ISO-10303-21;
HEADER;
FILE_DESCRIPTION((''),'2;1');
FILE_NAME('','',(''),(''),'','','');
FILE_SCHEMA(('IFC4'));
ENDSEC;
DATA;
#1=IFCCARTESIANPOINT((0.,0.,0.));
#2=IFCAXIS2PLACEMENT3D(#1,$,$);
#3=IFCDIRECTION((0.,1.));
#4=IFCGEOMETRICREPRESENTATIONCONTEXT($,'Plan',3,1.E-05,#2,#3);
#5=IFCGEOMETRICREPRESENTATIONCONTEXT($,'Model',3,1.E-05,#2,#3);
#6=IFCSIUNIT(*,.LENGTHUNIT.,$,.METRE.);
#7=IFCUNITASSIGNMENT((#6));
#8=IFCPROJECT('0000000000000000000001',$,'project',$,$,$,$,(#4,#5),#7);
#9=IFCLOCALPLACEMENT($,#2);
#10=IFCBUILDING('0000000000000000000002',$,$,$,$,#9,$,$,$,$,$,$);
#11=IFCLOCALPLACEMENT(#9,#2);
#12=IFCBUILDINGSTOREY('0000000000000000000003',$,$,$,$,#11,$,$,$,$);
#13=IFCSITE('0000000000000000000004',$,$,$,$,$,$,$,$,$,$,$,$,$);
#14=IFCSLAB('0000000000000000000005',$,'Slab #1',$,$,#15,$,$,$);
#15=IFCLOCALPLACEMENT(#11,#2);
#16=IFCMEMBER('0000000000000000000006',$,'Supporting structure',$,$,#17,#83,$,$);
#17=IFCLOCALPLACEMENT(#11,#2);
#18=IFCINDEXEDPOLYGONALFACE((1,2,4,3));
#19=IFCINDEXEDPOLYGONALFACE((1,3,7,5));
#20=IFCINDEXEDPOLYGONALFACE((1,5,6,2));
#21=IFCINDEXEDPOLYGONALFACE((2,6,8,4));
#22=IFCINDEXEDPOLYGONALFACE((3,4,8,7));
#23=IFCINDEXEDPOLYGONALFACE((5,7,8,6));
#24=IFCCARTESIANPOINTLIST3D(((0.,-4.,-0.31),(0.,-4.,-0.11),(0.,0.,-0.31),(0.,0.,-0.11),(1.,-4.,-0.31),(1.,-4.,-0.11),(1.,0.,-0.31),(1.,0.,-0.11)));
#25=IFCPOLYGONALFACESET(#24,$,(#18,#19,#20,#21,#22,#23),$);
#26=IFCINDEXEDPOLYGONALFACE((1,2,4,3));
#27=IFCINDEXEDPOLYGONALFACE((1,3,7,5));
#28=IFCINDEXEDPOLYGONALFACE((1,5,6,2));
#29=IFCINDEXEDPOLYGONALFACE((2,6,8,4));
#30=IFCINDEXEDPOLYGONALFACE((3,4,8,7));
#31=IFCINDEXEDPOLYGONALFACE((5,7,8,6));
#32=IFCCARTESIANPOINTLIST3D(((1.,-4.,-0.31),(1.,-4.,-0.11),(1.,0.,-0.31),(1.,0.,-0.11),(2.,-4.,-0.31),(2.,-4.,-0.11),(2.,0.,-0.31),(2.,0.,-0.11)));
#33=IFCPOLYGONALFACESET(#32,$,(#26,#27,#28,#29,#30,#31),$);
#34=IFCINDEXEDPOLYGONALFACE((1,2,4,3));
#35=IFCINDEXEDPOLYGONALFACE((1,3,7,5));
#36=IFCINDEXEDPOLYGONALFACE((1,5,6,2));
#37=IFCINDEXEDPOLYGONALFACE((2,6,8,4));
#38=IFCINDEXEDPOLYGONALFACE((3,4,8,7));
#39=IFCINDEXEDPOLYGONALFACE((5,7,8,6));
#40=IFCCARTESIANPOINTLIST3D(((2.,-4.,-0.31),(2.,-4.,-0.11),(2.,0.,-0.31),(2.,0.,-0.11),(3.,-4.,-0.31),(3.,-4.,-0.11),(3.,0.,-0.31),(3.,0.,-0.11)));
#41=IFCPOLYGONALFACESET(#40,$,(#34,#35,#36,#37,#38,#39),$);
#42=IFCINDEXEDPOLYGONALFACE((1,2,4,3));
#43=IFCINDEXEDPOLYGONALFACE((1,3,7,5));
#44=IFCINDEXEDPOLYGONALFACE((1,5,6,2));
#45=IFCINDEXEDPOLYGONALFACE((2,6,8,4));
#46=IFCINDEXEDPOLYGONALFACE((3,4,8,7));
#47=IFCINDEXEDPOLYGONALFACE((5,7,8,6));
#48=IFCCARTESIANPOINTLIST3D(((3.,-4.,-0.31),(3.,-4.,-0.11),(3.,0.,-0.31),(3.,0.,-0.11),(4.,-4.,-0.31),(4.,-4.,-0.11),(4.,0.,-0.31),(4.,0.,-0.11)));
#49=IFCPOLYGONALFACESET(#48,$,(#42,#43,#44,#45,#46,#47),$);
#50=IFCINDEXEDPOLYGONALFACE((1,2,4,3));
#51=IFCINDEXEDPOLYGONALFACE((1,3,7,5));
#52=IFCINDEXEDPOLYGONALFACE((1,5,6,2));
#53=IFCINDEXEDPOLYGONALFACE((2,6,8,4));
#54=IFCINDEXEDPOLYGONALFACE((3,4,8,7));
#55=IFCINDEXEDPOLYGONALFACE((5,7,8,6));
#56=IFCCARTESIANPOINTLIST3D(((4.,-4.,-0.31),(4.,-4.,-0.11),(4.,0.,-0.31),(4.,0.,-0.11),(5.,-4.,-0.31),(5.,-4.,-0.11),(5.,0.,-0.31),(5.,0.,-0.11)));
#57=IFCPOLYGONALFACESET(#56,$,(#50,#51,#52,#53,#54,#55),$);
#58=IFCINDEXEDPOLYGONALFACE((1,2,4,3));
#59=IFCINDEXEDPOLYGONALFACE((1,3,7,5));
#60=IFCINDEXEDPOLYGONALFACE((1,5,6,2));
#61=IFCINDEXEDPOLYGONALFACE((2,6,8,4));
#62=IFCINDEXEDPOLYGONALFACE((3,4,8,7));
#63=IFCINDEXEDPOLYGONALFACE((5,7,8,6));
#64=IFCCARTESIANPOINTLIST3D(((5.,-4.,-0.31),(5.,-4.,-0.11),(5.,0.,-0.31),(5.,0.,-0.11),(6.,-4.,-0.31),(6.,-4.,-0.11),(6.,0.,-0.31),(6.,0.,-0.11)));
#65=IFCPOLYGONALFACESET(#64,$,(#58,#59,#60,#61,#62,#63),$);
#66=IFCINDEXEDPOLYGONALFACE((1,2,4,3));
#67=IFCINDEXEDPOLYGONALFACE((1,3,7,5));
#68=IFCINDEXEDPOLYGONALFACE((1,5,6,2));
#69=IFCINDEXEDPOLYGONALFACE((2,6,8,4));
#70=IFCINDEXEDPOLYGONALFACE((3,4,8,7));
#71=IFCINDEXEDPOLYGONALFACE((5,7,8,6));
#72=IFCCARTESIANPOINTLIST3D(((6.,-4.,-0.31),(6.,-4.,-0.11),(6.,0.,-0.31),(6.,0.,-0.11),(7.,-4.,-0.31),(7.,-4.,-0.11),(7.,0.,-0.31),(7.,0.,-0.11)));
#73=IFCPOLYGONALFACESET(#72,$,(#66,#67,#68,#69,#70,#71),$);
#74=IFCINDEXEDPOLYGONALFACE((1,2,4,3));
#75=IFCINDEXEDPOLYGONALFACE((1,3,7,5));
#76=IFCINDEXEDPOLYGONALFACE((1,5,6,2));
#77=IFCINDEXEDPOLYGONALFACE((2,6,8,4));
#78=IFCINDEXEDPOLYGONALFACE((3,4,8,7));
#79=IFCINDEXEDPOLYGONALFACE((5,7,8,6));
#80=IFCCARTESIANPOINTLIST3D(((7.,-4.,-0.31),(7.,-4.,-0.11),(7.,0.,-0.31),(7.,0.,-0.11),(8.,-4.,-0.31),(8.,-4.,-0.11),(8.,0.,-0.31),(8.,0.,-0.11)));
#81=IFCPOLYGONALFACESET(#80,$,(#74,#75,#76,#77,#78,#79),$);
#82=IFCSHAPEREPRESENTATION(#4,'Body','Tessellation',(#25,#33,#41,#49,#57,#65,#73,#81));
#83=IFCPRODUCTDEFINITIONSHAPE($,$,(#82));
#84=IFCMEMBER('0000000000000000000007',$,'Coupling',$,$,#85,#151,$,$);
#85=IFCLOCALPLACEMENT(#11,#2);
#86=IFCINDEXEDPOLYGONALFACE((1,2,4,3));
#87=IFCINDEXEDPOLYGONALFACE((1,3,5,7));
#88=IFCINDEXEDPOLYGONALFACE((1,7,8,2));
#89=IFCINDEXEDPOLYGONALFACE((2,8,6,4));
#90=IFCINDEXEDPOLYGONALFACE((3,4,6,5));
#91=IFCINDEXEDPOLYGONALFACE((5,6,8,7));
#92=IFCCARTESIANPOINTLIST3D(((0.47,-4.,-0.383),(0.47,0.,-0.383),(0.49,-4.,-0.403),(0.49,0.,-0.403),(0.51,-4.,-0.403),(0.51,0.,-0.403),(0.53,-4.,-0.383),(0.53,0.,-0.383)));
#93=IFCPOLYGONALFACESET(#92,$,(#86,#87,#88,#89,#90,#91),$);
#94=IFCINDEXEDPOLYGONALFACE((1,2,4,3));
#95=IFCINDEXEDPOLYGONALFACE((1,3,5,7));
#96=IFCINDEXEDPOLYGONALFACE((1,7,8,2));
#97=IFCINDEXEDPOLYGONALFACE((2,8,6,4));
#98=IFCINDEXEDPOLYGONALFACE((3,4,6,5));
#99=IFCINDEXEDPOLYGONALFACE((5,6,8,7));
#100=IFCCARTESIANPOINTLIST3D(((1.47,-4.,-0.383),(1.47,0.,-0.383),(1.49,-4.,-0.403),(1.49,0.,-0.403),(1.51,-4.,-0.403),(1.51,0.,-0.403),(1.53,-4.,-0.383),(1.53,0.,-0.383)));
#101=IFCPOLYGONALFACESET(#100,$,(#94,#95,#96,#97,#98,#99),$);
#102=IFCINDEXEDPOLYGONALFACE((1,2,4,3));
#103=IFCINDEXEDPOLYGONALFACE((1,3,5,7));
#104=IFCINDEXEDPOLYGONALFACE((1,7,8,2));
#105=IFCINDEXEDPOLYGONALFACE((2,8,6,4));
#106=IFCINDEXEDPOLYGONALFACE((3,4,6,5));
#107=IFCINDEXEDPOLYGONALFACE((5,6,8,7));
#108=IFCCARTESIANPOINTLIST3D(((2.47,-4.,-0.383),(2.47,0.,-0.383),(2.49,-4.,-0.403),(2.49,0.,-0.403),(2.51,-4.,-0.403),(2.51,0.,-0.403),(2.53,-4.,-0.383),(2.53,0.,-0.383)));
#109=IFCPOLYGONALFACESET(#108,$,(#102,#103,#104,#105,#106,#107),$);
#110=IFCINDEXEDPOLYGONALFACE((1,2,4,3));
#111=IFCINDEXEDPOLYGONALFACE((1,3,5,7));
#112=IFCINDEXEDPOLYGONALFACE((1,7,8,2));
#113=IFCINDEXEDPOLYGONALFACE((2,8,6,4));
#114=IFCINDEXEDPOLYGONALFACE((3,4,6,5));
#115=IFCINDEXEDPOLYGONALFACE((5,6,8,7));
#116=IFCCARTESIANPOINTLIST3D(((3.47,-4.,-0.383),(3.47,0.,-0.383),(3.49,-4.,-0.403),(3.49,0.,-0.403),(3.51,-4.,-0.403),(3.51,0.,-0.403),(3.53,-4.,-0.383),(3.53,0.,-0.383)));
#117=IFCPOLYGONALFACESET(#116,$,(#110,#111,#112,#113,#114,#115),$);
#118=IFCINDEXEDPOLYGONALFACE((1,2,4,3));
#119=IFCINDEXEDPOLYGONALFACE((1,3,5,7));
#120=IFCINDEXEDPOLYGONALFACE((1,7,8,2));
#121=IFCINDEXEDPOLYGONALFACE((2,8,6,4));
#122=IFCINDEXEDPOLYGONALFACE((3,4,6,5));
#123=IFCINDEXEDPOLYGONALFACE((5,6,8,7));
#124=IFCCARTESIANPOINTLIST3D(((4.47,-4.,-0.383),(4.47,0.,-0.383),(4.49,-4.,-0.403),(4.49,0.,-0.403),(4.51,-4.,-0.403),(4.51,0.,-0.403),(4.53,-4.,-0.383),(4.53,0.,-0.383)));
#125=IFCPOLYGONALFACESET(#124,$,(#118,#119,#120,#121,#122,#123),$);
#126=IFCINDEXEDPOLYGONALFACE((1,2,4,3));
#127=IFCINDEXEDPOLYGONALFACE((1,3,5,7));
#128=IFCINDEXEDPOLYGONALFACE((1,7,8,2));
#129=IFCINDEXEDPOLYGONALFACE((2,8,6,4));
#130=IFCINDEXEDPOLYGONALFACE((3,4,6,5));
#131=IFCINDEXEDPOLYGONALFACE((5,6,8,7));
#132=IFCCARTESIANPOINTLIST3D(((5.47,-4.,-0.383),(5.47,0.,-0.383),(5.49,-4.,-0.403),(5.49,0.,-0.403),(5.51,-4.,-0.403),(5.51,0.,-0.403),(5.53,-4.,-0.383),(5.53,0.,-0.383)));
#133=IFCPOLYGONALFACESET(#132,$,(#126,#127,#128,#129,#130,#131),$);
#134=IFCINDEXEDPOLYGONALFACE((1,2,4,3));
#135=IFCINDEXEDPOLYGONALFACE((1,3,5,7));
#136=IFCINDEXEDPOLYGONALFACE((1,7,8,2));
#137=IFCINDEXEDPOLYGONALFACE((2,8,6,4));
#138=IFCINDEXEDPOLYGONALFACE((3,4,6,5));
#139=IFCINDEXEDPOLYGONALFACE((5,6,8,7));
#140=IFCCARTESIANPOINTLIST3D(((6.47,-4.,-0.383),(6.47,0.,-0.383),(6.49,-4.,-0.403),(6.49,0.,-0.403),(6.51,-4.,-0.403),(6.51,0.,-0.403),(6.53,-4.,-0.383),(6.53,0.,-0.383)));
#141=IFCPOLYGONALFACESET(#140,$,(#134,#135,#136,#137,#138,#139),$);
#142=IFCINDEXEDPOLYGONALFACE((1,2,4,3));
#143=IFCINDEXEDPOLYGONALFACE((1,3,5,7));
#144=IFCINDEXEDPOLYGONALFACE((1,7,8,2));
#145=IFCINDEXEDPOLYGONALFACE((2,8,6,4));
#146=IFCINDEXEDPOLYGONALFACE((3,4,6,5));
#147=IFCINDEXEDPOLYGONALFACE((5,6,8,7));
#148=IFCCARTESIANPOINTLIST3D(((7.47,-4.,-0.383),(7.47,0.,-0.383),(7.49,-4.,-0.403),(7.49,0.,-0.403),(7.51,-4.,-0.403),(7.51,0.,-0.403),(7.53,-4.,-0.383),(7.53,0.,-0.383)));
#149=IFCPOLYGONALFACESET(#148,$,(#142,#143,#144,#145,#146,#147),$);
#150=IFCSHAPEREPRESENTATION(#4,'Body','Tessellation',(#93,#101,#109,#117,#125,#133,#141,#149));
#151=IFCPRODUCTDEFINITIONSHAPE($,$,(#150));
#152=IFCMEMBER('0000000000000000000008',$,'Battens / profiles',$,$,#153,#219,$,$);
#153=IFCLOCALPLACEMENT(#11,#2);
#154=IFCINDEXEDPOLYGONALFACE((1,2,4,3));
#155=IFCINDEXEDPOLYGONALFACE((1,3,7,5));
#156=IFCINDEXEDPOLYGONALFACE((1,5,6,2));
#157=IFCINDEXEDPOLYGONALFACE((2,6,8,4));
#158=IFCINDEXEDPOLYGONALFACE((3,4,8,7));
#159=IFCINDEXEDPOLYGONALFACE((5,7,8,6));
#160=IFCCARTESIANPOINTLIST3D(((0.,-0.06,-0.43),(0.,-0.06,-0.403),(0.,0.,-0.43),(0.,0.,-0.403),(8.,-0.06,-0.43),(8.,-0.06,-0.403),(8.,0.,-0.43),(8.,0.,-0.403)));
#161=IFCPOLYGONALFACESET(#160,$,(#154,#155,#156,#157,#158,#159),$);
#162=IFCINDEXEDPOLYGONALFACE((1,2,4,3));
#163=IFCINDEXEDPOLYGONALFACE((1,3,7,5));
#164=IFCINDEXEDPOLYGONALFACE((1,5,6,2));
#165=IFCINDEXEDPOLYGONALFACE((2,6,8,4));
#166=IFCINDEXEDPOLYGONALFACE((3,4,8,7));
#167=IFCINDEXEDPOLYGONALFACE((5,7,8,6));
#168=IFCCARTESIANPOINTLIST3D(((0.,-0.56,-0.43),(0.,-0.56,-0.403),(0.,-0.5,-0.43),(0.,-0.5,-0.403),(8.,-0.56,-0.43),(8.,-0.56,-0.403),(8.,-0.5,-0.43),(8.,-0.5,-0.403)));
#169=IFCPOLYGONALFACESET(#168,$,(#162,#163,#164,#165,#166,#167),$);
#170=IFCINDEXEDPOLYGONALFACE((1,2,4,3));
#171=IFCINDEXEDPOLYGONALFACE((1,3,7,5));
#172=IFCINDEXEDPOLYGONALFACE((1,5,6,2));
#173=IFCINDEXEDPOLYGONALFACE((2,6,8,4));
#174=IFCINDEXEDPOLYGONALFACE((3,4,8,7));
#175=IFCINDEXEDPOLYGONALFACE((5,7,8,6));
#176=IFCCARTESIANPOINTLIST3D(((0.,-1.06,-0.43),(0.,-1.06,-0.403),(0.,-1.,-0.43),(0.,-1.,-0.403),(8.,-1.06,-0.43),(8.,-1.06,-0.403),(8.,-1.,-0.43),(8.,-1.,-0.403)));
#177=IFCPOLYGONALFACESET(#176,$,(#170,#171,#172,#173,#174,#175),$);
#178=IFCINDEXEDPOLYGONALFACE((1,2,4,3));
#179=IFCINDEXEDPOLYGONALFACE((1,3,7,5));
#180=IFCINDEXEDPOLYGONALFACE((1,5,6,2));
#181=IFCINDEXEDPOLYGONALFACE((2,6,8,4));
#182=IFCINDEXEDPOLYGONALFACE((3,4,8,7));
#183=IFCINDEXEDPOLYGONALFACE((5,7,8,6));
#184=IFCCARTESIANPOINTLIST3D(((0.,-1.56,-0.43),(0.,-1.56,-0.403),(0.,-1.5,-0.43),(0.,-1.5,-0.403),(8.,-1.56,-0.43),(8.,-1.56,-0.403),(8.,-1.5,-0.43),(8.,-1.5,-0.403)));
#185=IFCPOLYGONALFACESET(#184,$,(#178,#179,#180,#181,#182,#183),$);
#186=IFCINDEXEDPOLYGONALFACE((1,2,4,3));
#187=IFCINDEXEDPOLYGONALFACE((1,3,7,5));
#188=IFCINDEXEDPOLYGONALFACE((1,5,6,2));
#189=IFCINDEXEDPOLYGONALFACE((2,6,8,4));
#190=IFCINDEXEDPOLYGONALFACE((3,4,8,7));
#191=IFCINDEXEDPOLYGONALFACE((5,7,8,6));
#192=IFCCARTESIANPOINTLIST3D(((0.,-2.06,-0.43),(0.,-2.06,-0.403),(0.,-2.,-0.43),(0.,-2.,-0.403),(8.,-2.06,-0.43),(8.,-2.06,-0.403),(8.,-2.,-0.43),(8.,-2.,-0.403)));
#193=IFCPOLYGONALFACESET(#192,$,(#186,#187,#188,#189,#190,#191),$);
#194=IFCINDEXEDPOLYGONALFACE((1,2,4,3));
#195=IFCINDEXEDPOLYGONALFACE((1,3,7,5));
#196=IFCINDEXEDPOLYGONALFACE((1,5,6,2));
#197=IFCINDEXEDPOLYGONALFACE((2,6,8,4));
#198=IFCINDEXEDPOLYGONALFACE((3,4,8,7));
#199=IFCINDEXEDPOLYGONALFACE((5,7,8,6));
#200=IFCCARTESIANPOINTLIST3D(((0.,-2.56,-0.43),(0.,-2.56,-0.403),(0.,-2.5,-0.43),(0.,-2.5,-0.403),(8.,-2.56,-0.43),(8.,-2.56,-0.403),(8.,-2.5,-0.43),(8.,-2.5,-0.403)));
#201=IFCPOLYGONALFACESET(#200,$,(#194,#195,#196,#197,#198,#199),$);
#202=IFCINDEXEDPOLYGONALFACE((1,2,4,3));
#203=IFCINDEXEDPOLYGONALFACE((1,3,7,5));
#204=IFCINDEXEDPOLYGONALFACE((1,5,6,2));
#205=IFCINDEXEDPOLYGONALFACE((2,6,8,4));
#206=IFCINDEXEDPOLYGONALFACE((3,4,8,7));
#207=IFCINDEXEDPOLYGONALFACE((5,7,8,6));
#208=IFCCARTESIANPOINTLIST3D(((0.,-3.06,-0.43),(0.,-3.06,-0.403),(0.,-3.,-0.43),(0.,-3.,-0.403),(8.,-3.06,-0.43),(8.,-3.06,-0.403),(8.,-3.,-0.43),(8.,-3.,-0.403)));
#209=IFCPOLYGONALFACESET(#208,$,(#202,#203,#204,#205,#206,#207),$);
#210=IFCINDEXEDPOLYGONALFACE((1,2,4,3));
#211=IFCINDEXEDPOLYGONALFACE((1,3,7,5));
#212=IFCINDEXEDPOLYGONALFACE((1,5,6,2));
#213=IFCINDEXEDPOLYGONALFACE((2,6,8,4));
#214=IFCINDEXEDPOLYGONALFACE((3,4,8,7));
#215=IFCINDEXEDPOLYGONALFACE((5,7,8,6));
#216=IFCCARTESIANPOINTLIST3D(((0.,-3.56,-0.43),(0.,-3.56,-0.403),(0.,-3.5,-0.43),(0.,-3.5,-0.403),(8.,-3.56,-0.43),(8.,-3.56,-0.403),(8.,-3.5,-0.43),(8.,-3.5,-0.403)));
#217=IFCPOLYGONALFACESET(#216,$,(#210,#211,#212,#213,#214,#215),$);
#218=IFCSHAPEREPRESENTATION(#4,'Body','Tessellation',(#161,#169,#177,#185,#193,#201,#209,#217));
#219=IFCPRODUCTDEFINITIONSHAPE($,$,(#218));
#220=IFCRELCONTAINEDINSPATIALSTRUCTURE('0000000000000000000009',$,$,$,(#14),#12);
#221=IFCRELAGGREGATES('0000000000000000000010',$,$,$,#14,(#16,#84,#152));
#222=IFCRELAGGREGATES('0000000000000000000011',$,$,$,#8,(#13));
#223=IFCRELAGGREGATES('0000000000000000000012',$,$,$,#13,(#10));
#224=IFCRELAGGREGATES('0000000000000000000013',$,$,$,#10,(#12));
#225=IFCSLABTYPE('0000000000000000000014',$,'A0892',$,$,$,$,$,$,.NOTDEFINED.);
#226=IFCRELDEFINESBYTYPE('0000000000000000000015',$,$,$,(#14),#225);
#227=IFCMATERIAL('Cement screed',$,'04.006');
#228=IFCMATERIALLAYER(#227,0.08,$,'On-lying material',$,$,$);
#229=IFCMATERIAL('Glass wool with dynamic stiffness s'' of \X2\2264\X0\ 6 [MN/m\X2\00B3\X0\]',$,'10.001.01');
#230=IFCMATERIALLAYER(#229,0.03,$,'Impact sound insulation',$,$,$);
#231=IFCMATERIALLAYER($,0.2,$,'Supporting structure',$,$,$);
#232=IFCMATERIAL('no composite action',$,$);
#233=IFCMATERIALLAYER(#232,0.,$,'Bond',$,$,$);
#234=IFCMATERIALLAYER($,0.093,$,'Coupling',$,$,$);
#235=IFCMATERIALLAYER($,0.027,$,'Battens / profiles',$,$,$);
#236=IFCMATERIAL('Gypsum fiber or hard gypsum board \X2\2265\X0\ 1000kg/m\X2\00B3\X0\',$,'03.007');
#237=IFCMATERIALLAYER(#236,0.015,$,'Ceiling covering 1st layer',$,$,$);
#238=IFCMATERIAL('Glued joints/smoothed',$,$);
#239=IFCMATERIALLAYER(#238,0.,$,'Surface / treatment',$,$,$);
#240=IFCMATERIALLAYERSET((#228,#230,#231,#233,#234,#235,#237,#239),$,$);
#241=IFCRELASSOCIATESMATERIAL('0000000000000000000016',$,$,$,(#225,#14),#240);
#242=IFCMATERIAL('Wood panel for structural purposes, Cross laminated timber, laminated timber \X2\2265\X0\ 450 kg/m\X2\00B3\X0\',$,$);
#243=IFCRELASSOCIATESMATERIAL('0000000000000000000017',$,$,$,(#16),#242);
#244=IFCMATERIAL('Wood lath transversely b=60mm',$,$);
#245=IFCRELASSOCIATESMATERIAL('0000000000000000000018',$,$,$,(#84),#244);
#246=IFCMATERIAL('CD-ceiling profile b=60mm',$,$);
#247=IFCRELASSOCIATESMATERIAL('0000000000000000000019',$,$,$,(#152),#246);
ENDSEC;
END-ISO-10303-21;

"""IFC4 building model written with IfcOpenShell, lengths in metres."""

from ifc_helpers import new_model, si_unit, direction, frame, frame_2d, origin, place, context, project, spatial, polyline, rectangle, outline, extrude, material, layer, layer_set, type_object, element, aggregate, save


model = new_model("IFC4")

# Units and contexts
plan_context = context("Plan", 3, precision=1e-05, world=origin(), true_north=direction((0.0, 1.0)))
model_context = context("Model", 3, precision=1e-05, world=origin(), true_north=direction((0.0, 1.0)))
ifc_project = project(units=[si_unit("LENGTHUNIT", "METRE")], contexts=[plan_context, model_context])

# Site, building, storey
site = spatial("IfcSite", under=ifc_project)
building_placement = place(None, origin())
building = spatial("IfcBuilding", under=site, at=building_placement)
storey_placement = place(building_placement, origin())
storey = spatial("IfcBuildingStorey", under=building, at=storey_placement)

# Slab, members
ifc_material_1 = material(Name="Cement screed", Category="04.006")
ifc_layer_1 = layer(ifc_material_1, 0.08, Name="On-lying material")
ifc_material_2 = material(Name="Glass wool with dynamic stiffness s' of ≤ 6 [MN/m³]", Category="10.001.01")
ifc_layer_2 = layer(ifc_material_2, 0.03, Name="Impact sound insulation")
ifc_layer_3 = layer(None, 0.2, Name="Supporting structure")
ifc_material_3 = material(Name="no composite action")
ifc_layer_4 = layer(ifc_material_3, 0.0, Name="Bond")
ifc_layer_5 = layer(None, 0.093, Name="Coupling")
ifc_layer_6 = layer(None, 0.027, Name="Battens / profiles")
ifc_material_4 = material(Name="Gypsum fiber or hard gypsum board ≥ 1000kg/m³", Category="03.007")
ifc_layer_7 = layer(ifc_material_4, 0.015, Name="Ceiling covering 1st layer")
ifc_material_5 = material(Name="Glued joints/smoothed")
ifc_layer_8 = layer(ifc_material_5, 0.0, Name="Surface / treatment")
ifc_layer_set = layer_set([ifc_layer_1, ifc_layer_2, ifc_layer_3, ifc_layer_4, ifc_layer_5, ifc_layer_6, ifc_layer_7, ifc_layer_8])
slab_type = type_object("IfcSlabType", Name="A0892", PredefinedType="NOTDEFINED", material=ifc_layer_set)
slab_placement = place(None, frame((0.0, 0.0, 0.0), z_axis=(0.0, 0.0, -1.0), x_axis=(1.0, 0.0, 0.0)))
slab = element("IfcSlab", 1, at=slab_placement, inside=storey, type_object=slab_type, material=ifc_layer_set, Name="Slab #1")
ifc_material_6 = material(Name="Wood panel for structural purposes, Cross laminated timber, laminated timber ≥ 450 kg/m³")
member_1_placement = place(slab_placement, origin())
member_1 = element("IfcMember", 2, at=member_1_placement, material=ifc_material_6, Name="Supporting structure", context=plan_context, shape_type="SweptSolid", body=[
    extrude(rectangle(XDim=1.0, YDim=0.2, at=frame_2d((0.5, 0.1), x_axis=(1.0, 0.0))), frame((0.0, 4.0, 0.11), z_axis=(0.0, -1.0, 0.0), x_axis=(1.0, 0.0, 0.0)), (0.0, 0.0, 1.0), 4.0),
    extrude(rectangle(XDim=1.0, YDim=0.2, at=frame_2d((0.5, 0.1), x_axis=(1.0, 0.0))), frame((1.0, 4.0, 0.11), z_axis=(0.0, -1.0, 0.0), x_axis=(1.0, 0.0, 0.0)), (0.0, 0.0, 1.0), 4.0),
    extrude(rectangle(XDim=1.0, YDim=0.2, at=frame_2d((0.5, 0.1), x_axis=(1.0, 0.0))), frame((2.0, 4.0, 0.11), z_axis=(0.0, -1.0, 0.0), x_axis=(1.0, 0.0, 0.0)), (0.0, 0.0, 1.0), 4.0),
    extrude(rectangle(XDim=1.0, YDim=0.2, at=frame_2d((0.5, 0.1), x_axis=(1.0, 0.0))), frame((3.0, 4.0, 0.11), z_axis=(0.0, -1.0, 0.0), x_axis=(1.0, 0.0, 0.0)), (0.0, 0.0, 1.0), 4.0),
    extrude(rectangle(XDim=1.0, YDim=0.2, at=frame_2d((0.5, 0.1), x_axis=(1.0, 0.0))), frame((4.0, 4.0, 0.11), z_axis=(0.0, -1.0, 0.0), x_axis=(1.0, 0.0, 0.0)), (0.0, 0.0, 1.0), 4.0),
    extrude(rectangle(XDim=1.0, YDim=0.2, at=frame_2d((0.5, 0.1), x_axis=(1.0, 0.0))), frame((5.0, 4.0, 0.11), z_axis=(0.0, -1.0, 0.0), x_axis=(1.0, 0.0, 0.0)), (0.0, 0.0, 1.0), 4.0),
    extrude(rectangle(XDim=1.0, YDim=0.2, at=frame_2d((0.5, 0.1), x_axis=(1.0, 0.0))), frame((6.0, 4.0, 0.11), z_axis=(0.0, -1.0, 0.0), x_axis=(1.0, 0.0, 0.0)), (0.0, 0.0, 1.0), 4.0),
    extrude(rectangle(XDim=1.0, YDim=0.2, at=frame_2d((0.5, 0.1), x_axis=(1.0, 0.0))), frame((7.0, 4.0, 0.11), z_axis=(0.0, -1.0, 0.0), x_axis=(1.0, 0.0, 0.0)), (0.0, 0.0, 1.0), 4.0),
])
ifc_material_7 = material(Name="Wood lath transversely b=60mm")
member_2_placement = place(slab_placement, origin())
member_2 = element("IfcMember", 3, at=member_2_placement, material=ifc_material_7, Name="Coupling", context=plan_context, shape_type="SweptSolid", body=[
    extrude(outline(polyline([(0.0, 0.0), (0.06, 0.0), (0.04, 0.02), (0.02, 0.02), (0.0, 0.0)])), frame((0.47, 4.0, 0.383), z_axis=(0.0, -1.0, 0.0), x_axis=(1.0, 0.0, 0.0)), (0.0, 0.0, 1.0), 4.0),
    extrude(outline(polyline([(0.0, 0.0), (0.06, 0.0), (0.04, 0.02), (0.02, 0.02), (0.0, 0.0)])), frame((1.47, 4.0, 0.383), z_axis=(0.0, -1.0, 0.0), x_axis=(1.0, 0.0, 0.0)), (0.0, 0.0, 1.0), 4.0),
    extrude(outline(polyline([(0.0, 0.0), (0.06, 0.0), (0.04, 0.02), (0.02, 0.02), (0.0, 0.0)])), frame((2.47, 4.0, 0.383), z_axis=(0.0, -1.0, 0.0), x_axis=(1.0, 0.0, 0.0)), (0.0, 0.0, 1.0), 4.0),
    extrude(outline(polyline([(0.0, 0.0), (0.06, 0.0), (0.04, 0.02), (0.02, 0.02), (0.0, 0.0)])), frame((3.47, 4.0, 0.383), z_axis=(0.0, -1.0, 0.0), x_axis=(1.0, 0.0, 0.0)), (0.0, 0.0, 1.0), 4.0),
    extrude(outline(polyline([(0.0, 0.0), (0.06, 0.0), (0.04, 0.02), (0.02, 0.02), (0.0, 0.0)])), frame((4.47, 4.0, 0.383), z_axis=(0.0, -1.0, 0.0), x_axis=(1.0, 0.0, 0.0)), (0.0, 0.0, 1.0), 4.0),
    extrude(outline(polyline([(0.0, 0.0), (0.06, 0.0), (0.04, 0.02), (0.02, 0.02), (0.0, 0.0)])), frame((5.47, 4.0, 0.383), z_axis=(0.0, -1.0, 0.0), x_axis=(1.0, 0.0, 0.0)), (0.0, 0.0, 1.0), 4.0),
    extrude(outline(polyline([(0.0, 0.0), (0.06, 0.0), (0.04, 0.02), (0.02, 0.02), (0.0, 0.0)])), frame((6.47, 4.0, 0.383), z_axis=(0.0, -1.0, 0.0), x_axis=(1.0, 0.0, 0.0)), (0.0, 0.0, 1.0), 4.0),
    extrude(outline(polyline([(0.0, 0.0), (0.06, 0.0), (0.04, 0.02), (0.02, 0.02), (0.0, 0.0)])), frame((7.47, 4.0, 0.383), z_axis=(0.0, -1.0, 0.0), x_axis=(1.0, 0.0, 0.0)), (0.0, 0.0, 1.0), 4.0),
])
ifc_material_8 = material(Name="CD-ceiling profile b=60mm")
member_3_placement = place(slab_placement, origin())
member_3 = element("IfcMember", 4, at=member_3_placement, material=ifc_material_8, Name="Battens / profiles", context=plan_context, shape_type="SweptSolid", body=[
    extrude(rectangle(XDim=0.06, YDim=0.027, at=frame_2d((0.03, 0.0135), x_axis=(1.0, 0.0))), frame((0.0, 0.0, 0.403), z_axis=(1.0, 0.0, 0.0), x_axis=(0.0, 1.0, 0.0)), (0.0, 0.0, 1.0), 8.0),
    extrude(rectangle(XDim=0.06, YDim=0.027, at=frame_2d((0.03, 0.0135), x_axis=(1.0, 0.0))), frame((0.0, 0.5, 0.403), z_axis=(1.0, 0.0, 0.0), x_axis=(0.0, 1.0, 0.0)), (0.0, 0.0, 1.0), 8.0),
    extrude(rectangle(XDim=0.06, YDim=0.027, at=frame_2d((0.03, 0.0135), x_axis=(1.0, 0.0))), frame((0.0, 1.0, 0.403), z_axis=(1.0, 0.0, 0.0), x_axis=(0.0, 1.0, 0.0)), (0.0, 0.0, 1.0), 8.0),
    extrude(rectangle(XDim=0.06, YDim=0.027, at=frame_2d((0.03, 0.0135), x_axis=(1.0, 0.0))), frame((0.0, 1.5, 0.403), z_axis=(1.0, 0.0, 0.0), x_axis=(0.0, 1.0, 0.0)), (0.0, 0.0, 1.0), 8.0),
    extrude(rectangle(XDim=0.06, YDim=0.027, at=frame_2d((0.03, 0.0135), x_axis=(1.0, 0.0))), frame((0.0, 2.0, 0.403), z_axis=(1.0, 0.0, 0.0), x_axis=(0.0, 1.0, 0.0)), (0.0, 0.0, 1.0), 8.0),
    extrude(rectangle(XDim=0.06, YDim=0.027, at=frame_2d((0.03, 0.0135), x_axis=(1.0, 0.0))), frame((0.0, 2.5, 0.403), z_axis=(1.0, 0.0, 0.0), x_axis=(0.0, 1.0, 0.0)), (0.0, 0.0, 1.0), 8.0),
    extrude(rectangle(XDim=0.06, YDim=0.027, at=frame_2d((0.03, 0.0135), x_axis=(1.0, 0.0))), frame((0.0, 3.0, 0.403), z_axis=(1.0, 0.0, 0.0), x_axis=(0.0, 1.0, 0.0)), (0.0, 0.0, 1.0), 8.0),
    extrude(rectangle(XDim=0.06, YDim=0.027, at=frame_2d((0.03, 0.0135), x_axis=(1.0, 0.0))), frame((0.0, 3.5, 0.403), z_axis=(1.0, 0.0, 0.0), x_axis=(0.0, 1.0, 0.0)), (0.0, 0.0, 1.0), 8.0),
])
aggregate(slab, [member_1, member_2, member_3])

save(model, "model.ifc")
